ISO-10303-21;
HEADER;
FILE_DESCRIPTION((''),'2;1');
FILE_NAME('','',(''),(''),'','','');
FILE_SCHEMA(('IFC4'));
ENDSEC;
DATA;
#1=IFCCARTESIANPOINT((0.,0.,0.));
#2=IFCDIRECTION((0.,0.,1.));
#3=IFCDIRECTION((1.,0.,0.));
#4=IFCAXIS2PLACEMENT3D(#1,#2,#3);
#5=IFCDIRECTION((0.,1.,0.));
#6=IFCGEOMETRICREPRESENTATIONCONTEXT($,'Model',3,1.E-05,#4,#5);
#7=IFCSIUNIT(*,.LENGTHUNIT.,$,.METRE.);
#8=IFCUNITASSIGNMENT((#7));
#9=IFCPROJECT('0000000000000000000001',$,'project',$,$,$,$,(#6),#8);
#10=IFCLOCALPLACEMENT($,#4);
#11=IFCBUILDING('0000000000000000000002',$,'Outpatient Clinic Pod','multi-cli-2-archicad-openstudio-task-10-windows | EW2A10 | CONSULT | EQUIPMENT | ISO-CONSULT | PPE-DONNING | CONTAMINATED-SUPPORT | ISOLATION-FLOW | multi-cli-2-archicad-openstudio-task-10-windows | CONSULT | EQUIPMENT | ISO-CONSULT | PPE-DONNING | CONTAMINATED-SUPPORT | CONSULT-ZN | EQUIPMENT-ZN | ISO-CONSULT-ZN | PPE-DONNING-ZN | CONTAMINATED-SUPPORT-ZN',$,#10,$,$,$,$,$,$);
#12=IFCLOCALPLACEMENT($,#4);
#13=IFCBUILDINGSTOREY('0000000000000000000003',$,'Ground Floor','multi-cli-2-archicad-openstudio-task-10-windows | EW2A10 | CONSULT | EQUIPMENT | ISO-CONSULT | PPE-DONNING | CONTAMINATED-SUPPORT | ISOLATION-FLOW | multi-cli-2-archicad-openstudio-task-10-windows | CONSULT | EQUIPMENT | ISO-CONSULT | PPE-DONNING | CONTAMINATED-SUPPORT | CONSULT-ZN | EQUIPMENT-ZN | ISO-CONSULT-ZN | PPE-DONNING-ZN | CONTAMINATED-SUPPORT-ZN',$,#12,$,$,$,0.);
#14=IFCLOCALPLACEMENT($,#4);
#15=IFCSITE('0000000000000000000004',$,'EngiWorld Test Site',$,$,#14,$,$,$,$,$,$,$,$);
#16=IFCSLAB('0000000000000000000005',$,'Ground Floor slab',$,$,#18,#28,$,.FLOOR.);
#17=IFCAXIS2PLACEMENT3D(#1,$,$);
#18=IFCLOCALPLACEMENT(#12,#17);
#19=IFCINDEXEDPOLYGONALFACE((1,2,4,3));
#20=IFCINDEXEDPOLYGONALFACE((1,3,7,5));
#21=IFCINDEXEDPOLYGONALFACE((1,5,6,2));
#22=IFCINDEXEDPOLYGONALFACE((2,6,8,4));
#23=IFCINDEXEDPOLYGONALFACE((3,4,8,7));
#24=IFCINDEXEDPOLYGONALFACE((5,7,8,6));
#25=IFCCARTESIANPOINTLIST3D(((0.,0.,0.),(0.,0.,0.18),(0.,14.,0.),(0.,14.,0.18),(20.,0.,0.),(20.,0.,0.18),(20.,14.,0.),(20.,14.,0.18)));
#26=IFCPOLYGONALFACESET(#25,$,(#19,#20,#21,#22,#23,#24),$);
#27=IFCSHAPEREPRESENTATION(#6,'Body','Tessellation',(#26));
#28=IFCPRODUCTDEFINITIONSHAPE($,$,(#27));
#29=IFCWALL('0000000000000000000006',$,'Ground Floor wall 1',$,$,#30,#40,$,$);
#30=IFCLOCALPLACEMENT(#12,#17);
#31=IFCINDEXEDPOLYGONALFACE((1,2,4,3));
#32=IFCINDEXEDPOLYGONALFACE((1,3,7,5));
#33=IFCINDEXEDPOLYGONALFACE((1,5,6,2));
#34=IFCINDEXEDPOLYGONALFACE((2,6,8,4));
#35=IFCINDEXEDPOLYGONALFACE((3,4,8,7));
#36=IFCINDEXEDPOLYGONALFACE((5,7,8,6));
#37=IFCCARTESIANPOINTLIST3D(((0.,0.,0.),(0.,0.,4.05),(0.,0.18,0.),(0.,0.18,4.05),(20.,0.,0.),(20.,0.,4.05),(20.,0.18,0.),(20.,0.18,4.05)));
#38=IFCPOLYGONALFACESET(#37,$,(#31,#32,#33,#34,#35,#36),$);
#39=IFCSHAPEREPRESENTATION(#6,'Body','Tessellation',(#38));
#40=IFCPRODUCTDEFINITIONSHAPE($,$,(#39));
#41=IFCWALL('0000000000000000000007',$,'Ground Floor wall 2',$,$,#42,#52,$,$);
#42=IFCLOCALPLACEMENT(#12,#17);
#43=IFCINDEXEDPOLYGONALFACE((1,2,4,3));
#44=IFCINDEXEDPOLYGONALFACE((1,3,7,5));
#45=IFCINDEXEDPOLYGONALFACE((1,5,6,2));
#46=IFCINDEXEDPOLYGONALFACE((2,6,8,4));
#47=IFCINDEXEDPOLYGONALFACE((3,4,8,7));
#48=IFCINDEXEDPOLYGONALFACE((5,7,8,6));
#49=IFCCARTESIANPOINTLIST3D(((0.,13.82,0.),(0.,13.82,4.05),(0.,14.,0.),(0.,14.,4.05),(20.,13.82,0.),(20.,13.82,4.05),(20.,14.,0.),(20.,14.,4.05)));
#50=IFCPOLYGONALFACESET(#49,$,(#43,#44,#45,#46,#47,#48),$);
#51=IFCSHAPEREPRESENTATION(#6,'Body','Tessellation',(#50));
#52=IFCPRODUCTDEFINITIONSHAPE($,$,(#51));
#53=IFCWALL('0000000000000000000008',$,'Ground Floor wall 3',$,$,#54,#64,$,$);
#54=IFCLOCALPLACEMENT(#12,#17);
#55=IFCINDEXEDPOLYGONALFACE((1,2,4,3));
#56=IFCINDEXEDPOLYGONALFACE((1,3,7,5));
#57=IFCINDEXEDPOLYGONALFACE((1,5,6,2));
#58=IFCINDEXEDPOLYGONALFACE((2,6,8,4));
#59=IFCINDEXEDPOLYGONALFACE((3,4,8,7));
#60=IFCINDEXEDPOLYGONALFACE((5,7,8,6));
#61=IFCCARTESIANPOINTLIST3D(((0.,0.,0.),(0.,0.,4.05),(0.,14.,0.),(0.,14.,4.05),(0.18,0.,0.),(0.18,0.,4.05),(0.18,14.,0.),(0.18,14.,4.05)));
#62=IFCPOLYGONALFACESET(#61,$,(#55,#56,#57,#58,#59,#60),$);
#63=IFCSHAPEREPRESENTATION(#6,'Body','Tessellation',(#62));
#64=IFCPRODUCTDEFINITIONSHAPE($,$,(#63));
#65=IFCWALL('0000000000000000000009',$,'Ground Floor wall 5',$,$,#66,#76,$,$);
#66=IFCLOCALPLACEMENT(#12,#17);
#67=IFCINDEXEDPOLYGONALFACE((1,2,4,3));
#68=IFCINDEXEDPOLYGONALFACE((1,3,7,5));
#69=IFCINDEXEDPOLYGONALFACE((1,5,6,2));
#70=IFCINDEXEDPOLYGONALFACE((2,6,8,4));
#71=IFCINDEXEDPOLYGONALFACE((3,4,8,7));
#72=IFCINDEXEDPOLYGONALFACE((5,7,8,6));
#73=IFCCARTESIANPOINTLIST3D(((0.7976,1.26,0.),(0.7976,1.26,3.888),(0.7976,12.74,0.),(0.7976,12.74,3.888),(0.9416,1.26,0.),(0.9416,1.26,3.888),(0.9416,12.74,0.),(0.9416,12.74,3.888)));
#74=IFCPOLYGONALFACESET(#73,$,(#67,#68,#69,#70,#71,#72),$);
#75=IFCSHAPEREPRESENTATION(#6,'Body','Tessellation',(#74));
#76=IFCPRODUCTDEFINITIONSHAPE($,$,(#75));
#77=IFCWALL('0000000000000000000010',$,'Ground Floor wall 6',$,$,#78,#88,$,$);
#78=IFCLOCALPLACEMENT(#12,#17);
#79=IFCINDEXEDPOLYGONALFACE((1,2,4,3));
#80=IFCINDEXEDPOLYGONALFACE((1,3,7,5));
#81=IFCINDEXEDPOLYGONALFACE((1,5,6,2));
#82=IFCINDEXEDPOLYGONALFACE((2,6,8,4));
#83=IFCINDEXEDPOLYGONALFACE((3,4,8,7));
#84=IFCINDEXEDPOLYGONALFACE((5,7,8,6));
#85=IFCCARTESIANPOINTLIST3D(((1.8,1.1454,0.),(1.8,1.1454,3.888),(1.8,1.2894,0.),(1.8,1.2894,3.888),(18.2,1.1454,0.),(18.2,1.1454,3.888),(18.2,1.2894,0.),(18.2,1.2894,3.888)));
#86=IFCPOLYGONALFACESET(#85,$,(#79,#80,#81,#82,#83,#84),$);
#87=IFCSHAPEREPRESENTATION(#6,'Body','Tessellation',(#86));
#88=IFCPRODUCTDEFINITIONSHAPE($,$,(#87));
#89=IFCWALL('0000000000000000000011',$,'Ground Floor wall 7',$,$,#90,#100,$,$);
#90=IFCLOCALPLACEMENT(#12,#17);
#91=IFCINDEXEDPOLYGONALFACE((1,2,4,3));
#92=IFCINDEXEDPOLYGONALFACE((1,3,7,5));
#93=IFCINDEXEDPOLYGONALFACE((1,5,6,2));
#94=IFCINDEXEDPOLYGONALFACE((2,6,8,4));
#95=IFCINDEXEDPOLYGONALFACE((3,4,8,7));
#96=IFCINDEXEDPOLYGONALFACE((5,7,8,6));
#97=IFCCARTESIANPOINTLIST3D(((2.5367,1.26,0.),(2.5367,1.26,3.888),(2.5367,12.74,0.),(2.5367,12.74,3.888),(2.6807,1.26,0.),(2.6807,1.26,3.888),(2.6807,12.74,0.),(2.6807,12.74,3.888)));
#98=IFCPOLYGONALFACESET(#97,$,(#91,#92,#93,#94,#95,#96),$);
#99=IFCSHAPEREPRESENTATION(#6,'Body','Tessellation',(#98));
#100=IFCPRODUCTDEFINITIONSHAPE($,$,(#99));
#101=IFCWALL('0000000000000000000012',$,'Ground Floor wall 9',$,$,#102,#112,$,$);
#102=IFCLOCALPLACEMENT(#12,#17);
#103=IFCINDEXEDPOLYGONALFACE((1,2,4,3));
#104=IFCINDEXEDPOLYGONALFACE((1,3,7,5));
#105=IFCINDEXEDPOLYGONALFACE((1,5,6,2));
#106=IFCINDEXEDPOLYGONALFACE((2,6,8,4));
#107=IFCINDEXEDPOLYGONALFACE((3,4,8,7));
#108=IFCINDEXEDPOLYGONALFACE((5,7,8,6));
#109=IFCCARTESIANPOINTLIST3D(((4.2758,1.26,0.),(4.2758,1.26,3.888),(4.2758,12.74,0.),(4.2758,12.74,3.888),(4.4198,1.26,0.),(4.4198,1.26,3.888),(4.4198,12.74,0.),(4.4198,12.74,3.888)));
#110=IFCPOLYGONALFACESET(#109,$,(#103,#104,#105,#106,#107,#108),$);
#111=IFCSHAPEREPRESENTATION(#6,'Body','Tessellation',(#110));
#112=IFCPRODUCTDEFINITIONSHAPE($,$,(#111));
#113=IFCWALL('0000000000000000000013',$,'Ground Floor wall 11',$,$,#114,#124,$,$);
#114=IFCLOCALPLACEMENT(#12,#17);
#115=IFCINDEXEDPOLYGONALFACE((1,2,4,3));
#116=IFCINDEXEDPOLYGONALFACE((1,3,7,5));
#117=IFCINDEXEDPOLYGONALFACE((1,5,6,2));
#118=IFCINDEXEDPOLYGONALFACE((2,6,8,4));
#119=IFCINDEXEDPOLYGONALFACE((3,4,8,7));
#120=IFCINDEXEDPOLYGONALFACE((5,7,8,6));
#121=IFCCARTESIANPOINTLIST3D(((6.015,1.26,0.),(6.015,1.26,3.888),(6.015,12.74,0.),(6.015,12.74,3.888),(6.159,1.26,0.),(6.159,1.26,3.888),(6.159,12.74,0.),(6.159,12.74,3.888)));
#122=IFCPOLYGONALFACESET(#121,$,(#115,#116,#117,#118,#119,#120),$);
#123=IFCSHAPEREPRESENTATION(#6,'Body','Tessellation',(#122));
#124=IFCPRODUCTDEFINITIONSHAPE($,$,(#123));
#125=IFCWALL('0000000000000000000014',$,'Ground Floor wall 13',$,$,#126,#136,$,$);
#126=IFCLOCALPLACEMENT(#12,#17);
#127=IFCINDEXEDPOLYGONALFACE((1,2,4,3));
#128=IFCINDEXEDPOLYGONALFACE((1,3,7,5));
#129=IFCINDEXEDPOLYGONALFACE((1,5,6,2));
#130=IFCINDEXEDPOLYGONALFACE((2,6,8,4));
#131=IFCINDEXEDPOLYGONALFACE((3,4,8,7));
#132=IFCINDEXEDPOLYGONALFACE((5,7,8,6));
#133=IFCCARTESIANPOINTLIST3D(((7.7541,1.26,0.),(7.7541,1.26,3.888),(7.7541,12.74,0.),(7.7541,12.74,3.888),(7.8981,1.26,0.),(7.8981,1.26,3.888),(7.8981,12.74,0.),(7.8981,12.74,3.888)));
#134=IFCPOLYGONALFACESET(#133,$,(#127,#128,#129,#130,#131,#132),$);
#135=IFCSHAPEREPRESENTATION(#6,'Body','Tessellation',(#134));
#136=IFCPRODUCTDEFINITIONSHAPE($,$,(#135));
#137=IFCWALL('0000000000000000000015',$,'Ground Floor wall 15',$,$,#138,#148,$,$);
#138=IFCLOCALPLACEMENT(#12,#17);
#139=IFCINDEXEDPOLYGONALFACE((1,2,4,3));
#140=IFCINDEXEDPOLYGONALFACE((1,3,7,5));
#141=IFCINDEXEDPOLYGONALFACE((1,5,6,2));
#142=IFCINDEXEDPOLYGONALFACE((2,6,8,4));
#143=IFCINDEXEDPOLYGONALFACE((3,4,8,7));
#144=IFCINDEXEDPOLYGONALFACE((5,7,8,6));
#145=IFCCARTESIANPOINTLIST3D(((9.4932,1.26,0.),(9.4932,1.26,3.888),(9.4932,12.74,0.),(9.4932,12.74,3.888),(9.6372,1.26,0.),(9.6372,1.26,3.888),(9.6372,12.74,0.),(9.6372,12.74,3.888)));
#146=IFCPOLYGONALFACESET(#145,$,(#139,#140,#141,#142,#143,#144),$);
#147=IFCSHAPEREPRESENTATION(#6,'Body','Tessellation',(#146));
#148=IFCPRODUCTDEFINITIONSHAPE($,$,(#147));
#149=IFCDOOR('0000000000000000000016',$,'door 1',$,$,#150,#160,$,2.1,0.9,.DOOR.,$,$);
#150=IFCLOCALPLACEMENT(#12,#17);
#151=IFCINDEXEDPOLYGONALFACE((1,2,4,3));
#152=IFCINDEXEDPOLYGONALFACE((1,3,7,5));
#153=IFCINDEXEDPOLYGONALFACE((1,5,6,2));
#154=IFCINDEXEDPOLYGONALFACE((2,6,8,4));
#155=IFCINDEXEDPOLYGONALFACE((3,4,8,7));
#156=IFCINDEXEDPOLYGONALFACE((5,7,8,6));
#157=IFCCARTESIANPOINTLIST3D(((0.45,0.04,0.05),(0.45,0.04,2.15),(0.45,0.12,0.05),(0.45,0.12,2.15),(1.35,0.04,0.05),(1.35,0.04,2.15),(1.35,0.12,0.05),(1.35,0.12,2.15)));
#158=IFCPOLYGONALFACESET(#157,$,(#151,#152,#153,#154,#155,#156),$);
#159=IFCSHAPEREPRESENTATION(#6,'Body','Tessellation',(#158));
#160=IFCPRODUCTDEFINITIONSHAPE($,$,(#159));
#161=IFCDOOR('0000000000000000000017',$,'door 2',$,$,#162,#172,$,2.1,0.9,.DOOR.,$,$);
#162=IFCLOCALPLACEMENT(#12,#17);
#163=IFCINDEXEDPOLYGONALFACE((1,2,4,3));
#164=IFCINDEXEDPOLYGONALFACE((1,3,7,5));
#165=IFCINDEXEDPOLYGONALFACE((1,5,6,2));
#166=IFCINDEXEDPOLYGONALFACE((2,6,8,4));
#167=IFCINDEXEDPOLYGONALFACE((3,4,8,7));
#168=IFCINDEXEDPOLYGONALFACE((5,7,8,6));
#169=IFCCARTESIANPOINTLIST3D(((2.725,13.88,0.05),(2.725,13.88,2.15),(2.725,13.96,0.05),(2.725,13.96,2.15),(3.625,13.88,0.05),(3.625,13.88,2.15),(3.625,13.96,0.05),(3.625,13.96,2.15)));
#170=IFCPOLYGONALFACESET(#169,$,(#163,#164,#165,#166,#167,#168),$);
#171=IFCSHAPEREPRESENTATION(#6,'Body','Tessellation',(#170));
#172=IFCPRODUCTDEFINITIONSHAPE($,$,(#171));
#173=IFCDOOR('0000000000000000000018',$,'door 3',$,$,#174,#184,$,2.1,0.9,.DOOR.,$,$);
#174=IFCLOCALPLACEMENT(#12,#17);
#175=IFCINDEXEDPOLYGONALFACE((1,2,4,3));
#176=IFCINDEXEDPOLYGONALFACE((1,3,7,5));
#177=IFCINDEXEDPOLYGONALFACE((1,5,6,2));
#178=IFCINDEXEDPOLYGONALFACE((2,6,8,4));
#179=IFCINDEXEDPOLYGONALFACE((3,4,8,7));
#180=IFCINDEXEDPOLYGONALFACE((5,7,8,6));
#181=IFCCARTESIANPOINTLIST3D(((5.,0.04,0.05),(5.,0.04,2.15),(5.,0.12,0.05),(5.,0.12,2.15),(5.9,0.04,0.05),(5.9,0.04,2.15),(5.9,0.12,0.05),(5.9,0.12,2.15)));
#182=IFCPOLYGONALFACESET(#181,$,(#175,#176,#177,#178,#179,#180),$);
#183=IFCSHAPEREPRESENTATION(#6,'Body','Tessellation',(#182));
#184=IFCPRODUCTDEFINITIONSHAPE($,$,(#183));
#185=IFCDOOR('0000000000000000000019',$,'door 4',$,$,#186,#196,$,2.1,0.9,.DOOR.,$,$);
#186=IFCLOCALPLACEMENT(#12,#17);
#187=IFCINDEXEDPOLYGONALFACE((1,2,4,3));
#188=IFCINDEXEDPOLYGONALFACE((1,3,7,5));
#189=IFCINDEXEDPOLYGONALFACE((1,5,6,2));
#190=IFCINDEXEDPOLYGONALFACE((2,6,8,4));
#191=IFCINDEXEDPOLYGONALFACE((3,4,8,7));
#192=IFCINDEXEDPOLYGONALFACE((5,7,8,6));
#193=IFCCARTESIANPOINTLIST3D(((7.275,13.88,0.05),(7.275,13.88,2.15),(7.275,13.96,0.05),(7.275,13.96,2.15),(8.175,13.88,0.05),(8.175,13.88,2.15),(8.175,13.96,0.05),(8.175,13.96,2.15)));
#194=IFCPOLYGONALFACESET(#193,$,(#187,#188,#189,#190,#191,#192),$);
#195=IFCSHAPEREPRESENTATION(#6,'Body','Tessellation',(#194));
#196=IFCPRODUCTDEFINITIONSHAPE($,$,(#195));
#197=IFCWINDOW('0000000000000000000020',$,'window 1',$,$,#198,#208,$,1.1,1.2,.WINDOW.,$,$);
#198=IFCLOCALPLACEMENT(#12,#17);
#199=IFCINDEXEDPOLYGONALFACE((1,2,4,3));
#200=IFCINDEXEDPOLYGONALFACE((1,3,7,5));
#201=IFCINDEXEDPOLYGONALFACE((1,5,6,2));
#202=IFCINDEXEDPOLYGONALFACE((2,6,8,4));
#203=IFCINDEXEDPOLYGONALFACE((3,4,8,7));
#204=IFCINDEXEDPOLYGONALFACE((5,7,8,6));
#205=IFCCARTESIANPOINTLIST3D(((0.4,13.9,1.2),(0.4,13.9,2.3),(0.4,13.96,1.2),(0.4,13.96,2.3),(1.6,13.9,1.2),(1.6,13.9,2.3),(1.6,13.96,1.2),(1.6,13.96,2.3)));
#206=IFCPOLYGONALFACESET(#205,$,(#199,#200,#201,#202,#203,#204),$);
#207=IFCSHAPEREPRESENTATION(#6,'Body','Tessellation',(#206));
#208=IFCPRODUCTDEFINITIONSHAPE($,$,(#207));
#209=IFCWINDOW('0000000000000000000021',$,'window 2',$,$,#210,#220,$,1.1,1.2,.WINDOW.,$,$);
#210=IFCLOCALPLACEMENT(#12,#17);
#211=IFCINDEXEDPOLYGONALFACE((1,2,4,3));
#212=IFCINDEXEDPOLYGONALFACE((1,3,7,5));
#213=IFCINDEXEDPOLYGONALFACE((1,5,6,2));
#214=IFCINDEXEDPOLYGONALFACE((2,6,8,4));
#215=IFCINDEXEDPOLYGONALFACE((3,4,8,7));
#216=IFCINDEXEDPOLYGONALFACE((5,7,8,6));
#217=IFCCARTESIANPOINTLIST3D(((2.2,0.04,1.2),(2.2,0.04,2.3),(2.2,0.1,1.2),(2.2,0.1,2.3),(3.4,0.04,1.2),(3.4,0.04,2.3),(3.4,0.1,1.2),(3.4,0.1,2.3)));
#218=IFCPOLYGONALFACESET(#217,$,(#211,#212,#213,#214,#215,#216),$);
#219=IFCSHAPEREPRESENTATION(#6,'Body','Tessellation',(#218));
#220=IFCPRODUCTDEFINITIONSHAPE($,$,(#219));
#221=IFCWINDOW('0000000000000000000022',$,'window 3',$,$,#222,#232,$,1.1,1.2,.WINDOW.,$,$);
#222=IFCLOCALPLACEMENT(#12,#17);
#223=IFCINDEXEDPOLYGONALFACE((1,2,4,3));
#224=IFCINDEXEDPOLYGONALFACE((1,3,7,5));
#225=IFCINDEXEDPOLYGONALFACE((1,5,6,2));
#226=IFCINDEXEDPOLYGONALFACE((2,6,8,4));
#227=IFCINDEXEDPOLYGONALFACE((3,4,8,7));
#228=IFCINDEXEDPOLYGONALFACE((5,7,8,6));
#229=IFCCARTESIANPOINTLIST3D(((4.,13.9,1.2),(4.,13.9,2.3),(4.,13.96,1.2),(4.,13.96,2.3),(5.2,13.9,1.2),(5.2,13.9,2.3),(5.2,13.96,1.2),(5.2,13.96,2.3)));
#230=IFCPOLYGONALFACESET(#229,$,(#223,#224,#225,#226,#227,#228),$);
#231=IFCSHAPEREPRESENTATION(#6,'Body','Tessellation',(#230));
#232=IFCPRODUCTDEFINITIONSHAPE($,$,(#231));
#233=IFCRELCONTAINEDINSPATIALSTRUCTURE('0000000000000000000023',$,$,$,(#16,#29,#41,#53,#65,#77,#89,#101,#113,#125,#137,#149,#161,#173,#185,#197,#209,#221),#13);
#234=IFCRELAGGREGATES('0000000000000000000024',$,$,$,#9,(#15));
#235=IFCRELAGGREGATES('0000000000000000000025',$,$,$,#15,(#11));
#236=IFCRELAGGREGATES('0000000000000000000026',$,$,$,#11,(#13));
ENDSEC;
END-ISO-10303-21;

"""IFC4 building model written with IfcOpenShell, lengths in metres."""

from ifc_helpers import new_model, si_unit, direction, frame, origin_with_axes, origin_2d_with_axis, place, context, project, spatial, rectangle, extrude, element, save


model = new_model("IFC4")

# Units and contexts
model_context = context("Model", 3, precision=1e-05, world=origin_with_axes(), true_north=direction((0.0, 1.0, 0.0)))
ifc_project = project(units=[si_unit("LENGTHUNIT", "METRE")], contexts=[model_context])

# Site, building, storey
site_placement = place(None, origin_with_axes())
site = spatial("IfcSite", under=ifc_project, at=site_placement, Name="EngiWorld Test Site")
building_placement = place(None, origin_with_axes())
building = spatial("IfcBuilding", under=site, at=building_placement, Name="Outpatient Clinic Pod", Description="multi-cli-2-archicad-openstudio-task-10-windows | EW2A10 | CONSULT | EQUIPMENT | ISO-CONSULT | PPE-DONNING | CONTAMINATED-SUPPORT | ISOLATION-FLOW | multi-cli-2-archicad-openstudio-task-10-windows | CONSULT | EQUIPMENT | ISO-CONSULT | PPE-DONNING | CONTAMINATED-SUPPORT | CONSULT-ZN | EQUIPMENT-ZN | ISO-CONSULT-ZN | PPE-DONNING-ZN | CONTAMINATED-SUPPORT-ZN")
storey_placement = place(None, origin_with_axes())
storey = spatial("IfcBuildingStorey", under=building, at=storey_placement, Name="Ground Floor", Description="multi-cli-2-archicad-openstudio-task-10-windows | EW2A10 | CONSULT | EQUIPMENT | ISO-CONSULT | PPE-DONNING | CONTAMINATED-SUPPORT | ISOLATION-FLOW | multi-cli-2-archicad-openstudio-task-10-windows | CONSULT | EQUIPMENT | ISO-CONSULT | PPE-DONNING | CONTAMINATED-SUPPORT | CONSULT-ZN | EQUIPMENT-ZN | ISO-CONSULT-ZN | PPE-DONNING-ZN | CONTAMINATED-SUPPORT-ZN", Elevation=0.0)

# Slab
slab_placement = place(None, frame((10.0, 7.0, 0.0), z_axis=(0.0, 0.0, 1.0), x_axis=(1.0, 0.0, 0.0)))
element("IfcSlab", 1, at=slab_placement, inside=storey, Name="Ground Floor slab", PredefinedType="FLOOR", context=model_context, shape_type="SweptSolid", body=[
    extrude(rectangle(XDim=20.0, YDim=14.0, at=origin_2d_with_axis()), origin_with_axes(), (0.0, 0.0, 1.0), 0.18),
])

# Walls
for number, where, z_axis, x_axis, name in (
    (2, (10.0, 0.09, 0.0), (0.0, 0.0, 1.0), (1.0, 0.0, 0.0), "Ground Floor wall 1"),
    (3, (10.0, 13.91, 0.0), (0.0, 0.0, 1.0), (1.0, 0.0, 0.0), "Ground Floor wall 2"),
):
    element("IfcWall", number, at=place(None, frame(where, z_axis=z_axis, x_axis=x_axis)), inside=storey, Name=name, context=model_context, shape_type="SweptSolid", body=[
        extrude(rectangle(XDim=20.0, YDim=0.18, at=origin_2d_with_axis()), origin_with_axes(), (0.0, 0.0, 1.0), 4.05),
    ])
wall_1_placement = place(None, frame((0.09, 7.0, 0.0), z_axis=(0.0, 0.0, 1.0), x_axis=(1.0, 0.0, 0.0)))
element("IfcWall", 4, at=wall_1_placement, inside=storey, Name="Ground Floor wall 3", context=model_context, shape_type="SweptSolid", body=[
    extrude(rectangle(XDim=0.18, YDim=14.0, at=origin_2d_with_axis()), origin_with_axes(), (0.0, 0.0, 1.0), 4.05),
])
wall_2_placement = place(None, frame((0.8696, 7.0, 0.0), z_axis=(0.0, 0.0, 1.0), x_axis=(1.0, 0.0, 0.0)))
element("IfcWall", 5, at=wall_2_placement, inside=storey, Name="Ground Floor wall 5", context=model_context, shape_type="SweptSolid", body=[
    extrude(rectangle(XDim=0.144, YDim=11.48, at=origin_2d_with_axis()), origin_with_axes(), (0.0, 0.0, 1.0), 3.888),
])
wall_3_placement = place(None, frame((10.0, 1.2174, 0.0), z_axis=(0.0, 0.0, 1.0), x_axis=(1.0, 0.0, 0.0)))
element("IfcWall", 6, at=wall_3_placement, inside=storey, Name="Ground Floor wall 6", context=model_context, shape_type="SweptSolid", body=[
    extrude(rectangle(XDim=16.4, YDim=0.144, at=origin_2d_with_axis()), origin_with_axes(), (0.0, 0.0, 1.0), 3.888),
])
for number, where, z_axis, x_axis, name in (
    (7, (2.6087, 7.0, 0.0), (0.0, 0.0, 1.0), (1.0, 0.0, 0.0), "Ground Floor wall 7"),
    (8, (4.3478, 7.0, 0.0), (0.0, 0.0, 1.0), (1.0, 0.0, 0.0), "Ground Floor wall 9"),
    (9, (6.087, 7.0, 0.0), (0.0, 0.0, 1.0), (1.0, 0.0, 0.0), "Ground Floor wall 11"),
    (10, (7.8261, 7.0, 0.0), (0.0, 0.0, 1.0), (1.0, 0.0, 0.0), "Ground Floor wall 13"),
    (11, (9.5652, 7.0, 0.0), (0.0, 0.0, 1.0), (1.0, 0.0, 0.0), "Ground Floor wall 15"),
):
    element("IfcWall", number, at=place(None, frame(where, z_axis=z_axis, x_axis=x_axis)), inside=storey, Name=name, context=model_context, shape_type="SweptSolid", body=[
        extrude(rectangle(XDim=0.144, YDim=11.48, at=origin_2d_with_axis()), origin_with_axes(), (0.0, 0.0, 1.0), 3.888),
    ])

# Doors
for number, where, z_axis, x_axis, name in (
    (12, (0.9, 0.08, 0.05), (0.0, 0.0, 1.0), (1.0, 0.0, 0.0), "door 1"),
    (13, (3.175, 13.92, 0.05), (0.0, 0.0, 1.0), (1.0, 0.0, 0.0), "door 2"),
    (14, (5.45, 0.08, 0.05), (0.0, 0.0, 1.0), (1.0, 0.0, 0.0), "door 3"),
    (15, (7.725, 13.92, 0.05), (0.0, 0.0, 1.0), (1.0, 0.0, 0.0), "door 4"),
):
    element("IfcDoor", number, at=place(None, frame(where, z_axis=z_axis, x_axis=x_axis)), inside=storey, Name=name, OverallHeight=2.1, OverallWidth=0.9, PredefinedType="DOOR", context=model_context, shape_type="SweptSolid", body=[
        extrude(rectangle(XDim=0.9, YDim=0.08, at=origin_2d_with_axis()), origin_with_axes(), (0.0, 0.0, 1.0), 2.1),
    ])

# Windows
for number, where, z_axis, x_axis, name in (
    (16, (1.0, 13.93, 1.2), (0.0, 0.0, 1.0), (1.0, 0.0, 0.0), "window 1"),
    (17, (2.8, 0.07, 1.2), (0.0, 0.0, 1.0), (1.0, 0.0, 0.0), "window 2"),
    (18, (4.6, 13.93, 1.2), (0.0, 0.0, 1.0), (1.0, 0.0, 0.0), "window 3"),
):
    element("IfcWindow", number, at=place(None, frame(where, z_axis=z_axis, x_axis=x_axis)), inside=storey, Name=name, OverallHeight=1.1, OverallWidth=1.2, PredefinedType="WINDOW", context=model_context, shape_type="SweptSolid", body=[
        extrude(rectangle(XDim=1.2, YDim=0.06, at=origin_2d_with_axis()), origin_with_axes(), (0.0, 0.0, 1.0), 1.1),
    ])

save(model, "model.ifc")
